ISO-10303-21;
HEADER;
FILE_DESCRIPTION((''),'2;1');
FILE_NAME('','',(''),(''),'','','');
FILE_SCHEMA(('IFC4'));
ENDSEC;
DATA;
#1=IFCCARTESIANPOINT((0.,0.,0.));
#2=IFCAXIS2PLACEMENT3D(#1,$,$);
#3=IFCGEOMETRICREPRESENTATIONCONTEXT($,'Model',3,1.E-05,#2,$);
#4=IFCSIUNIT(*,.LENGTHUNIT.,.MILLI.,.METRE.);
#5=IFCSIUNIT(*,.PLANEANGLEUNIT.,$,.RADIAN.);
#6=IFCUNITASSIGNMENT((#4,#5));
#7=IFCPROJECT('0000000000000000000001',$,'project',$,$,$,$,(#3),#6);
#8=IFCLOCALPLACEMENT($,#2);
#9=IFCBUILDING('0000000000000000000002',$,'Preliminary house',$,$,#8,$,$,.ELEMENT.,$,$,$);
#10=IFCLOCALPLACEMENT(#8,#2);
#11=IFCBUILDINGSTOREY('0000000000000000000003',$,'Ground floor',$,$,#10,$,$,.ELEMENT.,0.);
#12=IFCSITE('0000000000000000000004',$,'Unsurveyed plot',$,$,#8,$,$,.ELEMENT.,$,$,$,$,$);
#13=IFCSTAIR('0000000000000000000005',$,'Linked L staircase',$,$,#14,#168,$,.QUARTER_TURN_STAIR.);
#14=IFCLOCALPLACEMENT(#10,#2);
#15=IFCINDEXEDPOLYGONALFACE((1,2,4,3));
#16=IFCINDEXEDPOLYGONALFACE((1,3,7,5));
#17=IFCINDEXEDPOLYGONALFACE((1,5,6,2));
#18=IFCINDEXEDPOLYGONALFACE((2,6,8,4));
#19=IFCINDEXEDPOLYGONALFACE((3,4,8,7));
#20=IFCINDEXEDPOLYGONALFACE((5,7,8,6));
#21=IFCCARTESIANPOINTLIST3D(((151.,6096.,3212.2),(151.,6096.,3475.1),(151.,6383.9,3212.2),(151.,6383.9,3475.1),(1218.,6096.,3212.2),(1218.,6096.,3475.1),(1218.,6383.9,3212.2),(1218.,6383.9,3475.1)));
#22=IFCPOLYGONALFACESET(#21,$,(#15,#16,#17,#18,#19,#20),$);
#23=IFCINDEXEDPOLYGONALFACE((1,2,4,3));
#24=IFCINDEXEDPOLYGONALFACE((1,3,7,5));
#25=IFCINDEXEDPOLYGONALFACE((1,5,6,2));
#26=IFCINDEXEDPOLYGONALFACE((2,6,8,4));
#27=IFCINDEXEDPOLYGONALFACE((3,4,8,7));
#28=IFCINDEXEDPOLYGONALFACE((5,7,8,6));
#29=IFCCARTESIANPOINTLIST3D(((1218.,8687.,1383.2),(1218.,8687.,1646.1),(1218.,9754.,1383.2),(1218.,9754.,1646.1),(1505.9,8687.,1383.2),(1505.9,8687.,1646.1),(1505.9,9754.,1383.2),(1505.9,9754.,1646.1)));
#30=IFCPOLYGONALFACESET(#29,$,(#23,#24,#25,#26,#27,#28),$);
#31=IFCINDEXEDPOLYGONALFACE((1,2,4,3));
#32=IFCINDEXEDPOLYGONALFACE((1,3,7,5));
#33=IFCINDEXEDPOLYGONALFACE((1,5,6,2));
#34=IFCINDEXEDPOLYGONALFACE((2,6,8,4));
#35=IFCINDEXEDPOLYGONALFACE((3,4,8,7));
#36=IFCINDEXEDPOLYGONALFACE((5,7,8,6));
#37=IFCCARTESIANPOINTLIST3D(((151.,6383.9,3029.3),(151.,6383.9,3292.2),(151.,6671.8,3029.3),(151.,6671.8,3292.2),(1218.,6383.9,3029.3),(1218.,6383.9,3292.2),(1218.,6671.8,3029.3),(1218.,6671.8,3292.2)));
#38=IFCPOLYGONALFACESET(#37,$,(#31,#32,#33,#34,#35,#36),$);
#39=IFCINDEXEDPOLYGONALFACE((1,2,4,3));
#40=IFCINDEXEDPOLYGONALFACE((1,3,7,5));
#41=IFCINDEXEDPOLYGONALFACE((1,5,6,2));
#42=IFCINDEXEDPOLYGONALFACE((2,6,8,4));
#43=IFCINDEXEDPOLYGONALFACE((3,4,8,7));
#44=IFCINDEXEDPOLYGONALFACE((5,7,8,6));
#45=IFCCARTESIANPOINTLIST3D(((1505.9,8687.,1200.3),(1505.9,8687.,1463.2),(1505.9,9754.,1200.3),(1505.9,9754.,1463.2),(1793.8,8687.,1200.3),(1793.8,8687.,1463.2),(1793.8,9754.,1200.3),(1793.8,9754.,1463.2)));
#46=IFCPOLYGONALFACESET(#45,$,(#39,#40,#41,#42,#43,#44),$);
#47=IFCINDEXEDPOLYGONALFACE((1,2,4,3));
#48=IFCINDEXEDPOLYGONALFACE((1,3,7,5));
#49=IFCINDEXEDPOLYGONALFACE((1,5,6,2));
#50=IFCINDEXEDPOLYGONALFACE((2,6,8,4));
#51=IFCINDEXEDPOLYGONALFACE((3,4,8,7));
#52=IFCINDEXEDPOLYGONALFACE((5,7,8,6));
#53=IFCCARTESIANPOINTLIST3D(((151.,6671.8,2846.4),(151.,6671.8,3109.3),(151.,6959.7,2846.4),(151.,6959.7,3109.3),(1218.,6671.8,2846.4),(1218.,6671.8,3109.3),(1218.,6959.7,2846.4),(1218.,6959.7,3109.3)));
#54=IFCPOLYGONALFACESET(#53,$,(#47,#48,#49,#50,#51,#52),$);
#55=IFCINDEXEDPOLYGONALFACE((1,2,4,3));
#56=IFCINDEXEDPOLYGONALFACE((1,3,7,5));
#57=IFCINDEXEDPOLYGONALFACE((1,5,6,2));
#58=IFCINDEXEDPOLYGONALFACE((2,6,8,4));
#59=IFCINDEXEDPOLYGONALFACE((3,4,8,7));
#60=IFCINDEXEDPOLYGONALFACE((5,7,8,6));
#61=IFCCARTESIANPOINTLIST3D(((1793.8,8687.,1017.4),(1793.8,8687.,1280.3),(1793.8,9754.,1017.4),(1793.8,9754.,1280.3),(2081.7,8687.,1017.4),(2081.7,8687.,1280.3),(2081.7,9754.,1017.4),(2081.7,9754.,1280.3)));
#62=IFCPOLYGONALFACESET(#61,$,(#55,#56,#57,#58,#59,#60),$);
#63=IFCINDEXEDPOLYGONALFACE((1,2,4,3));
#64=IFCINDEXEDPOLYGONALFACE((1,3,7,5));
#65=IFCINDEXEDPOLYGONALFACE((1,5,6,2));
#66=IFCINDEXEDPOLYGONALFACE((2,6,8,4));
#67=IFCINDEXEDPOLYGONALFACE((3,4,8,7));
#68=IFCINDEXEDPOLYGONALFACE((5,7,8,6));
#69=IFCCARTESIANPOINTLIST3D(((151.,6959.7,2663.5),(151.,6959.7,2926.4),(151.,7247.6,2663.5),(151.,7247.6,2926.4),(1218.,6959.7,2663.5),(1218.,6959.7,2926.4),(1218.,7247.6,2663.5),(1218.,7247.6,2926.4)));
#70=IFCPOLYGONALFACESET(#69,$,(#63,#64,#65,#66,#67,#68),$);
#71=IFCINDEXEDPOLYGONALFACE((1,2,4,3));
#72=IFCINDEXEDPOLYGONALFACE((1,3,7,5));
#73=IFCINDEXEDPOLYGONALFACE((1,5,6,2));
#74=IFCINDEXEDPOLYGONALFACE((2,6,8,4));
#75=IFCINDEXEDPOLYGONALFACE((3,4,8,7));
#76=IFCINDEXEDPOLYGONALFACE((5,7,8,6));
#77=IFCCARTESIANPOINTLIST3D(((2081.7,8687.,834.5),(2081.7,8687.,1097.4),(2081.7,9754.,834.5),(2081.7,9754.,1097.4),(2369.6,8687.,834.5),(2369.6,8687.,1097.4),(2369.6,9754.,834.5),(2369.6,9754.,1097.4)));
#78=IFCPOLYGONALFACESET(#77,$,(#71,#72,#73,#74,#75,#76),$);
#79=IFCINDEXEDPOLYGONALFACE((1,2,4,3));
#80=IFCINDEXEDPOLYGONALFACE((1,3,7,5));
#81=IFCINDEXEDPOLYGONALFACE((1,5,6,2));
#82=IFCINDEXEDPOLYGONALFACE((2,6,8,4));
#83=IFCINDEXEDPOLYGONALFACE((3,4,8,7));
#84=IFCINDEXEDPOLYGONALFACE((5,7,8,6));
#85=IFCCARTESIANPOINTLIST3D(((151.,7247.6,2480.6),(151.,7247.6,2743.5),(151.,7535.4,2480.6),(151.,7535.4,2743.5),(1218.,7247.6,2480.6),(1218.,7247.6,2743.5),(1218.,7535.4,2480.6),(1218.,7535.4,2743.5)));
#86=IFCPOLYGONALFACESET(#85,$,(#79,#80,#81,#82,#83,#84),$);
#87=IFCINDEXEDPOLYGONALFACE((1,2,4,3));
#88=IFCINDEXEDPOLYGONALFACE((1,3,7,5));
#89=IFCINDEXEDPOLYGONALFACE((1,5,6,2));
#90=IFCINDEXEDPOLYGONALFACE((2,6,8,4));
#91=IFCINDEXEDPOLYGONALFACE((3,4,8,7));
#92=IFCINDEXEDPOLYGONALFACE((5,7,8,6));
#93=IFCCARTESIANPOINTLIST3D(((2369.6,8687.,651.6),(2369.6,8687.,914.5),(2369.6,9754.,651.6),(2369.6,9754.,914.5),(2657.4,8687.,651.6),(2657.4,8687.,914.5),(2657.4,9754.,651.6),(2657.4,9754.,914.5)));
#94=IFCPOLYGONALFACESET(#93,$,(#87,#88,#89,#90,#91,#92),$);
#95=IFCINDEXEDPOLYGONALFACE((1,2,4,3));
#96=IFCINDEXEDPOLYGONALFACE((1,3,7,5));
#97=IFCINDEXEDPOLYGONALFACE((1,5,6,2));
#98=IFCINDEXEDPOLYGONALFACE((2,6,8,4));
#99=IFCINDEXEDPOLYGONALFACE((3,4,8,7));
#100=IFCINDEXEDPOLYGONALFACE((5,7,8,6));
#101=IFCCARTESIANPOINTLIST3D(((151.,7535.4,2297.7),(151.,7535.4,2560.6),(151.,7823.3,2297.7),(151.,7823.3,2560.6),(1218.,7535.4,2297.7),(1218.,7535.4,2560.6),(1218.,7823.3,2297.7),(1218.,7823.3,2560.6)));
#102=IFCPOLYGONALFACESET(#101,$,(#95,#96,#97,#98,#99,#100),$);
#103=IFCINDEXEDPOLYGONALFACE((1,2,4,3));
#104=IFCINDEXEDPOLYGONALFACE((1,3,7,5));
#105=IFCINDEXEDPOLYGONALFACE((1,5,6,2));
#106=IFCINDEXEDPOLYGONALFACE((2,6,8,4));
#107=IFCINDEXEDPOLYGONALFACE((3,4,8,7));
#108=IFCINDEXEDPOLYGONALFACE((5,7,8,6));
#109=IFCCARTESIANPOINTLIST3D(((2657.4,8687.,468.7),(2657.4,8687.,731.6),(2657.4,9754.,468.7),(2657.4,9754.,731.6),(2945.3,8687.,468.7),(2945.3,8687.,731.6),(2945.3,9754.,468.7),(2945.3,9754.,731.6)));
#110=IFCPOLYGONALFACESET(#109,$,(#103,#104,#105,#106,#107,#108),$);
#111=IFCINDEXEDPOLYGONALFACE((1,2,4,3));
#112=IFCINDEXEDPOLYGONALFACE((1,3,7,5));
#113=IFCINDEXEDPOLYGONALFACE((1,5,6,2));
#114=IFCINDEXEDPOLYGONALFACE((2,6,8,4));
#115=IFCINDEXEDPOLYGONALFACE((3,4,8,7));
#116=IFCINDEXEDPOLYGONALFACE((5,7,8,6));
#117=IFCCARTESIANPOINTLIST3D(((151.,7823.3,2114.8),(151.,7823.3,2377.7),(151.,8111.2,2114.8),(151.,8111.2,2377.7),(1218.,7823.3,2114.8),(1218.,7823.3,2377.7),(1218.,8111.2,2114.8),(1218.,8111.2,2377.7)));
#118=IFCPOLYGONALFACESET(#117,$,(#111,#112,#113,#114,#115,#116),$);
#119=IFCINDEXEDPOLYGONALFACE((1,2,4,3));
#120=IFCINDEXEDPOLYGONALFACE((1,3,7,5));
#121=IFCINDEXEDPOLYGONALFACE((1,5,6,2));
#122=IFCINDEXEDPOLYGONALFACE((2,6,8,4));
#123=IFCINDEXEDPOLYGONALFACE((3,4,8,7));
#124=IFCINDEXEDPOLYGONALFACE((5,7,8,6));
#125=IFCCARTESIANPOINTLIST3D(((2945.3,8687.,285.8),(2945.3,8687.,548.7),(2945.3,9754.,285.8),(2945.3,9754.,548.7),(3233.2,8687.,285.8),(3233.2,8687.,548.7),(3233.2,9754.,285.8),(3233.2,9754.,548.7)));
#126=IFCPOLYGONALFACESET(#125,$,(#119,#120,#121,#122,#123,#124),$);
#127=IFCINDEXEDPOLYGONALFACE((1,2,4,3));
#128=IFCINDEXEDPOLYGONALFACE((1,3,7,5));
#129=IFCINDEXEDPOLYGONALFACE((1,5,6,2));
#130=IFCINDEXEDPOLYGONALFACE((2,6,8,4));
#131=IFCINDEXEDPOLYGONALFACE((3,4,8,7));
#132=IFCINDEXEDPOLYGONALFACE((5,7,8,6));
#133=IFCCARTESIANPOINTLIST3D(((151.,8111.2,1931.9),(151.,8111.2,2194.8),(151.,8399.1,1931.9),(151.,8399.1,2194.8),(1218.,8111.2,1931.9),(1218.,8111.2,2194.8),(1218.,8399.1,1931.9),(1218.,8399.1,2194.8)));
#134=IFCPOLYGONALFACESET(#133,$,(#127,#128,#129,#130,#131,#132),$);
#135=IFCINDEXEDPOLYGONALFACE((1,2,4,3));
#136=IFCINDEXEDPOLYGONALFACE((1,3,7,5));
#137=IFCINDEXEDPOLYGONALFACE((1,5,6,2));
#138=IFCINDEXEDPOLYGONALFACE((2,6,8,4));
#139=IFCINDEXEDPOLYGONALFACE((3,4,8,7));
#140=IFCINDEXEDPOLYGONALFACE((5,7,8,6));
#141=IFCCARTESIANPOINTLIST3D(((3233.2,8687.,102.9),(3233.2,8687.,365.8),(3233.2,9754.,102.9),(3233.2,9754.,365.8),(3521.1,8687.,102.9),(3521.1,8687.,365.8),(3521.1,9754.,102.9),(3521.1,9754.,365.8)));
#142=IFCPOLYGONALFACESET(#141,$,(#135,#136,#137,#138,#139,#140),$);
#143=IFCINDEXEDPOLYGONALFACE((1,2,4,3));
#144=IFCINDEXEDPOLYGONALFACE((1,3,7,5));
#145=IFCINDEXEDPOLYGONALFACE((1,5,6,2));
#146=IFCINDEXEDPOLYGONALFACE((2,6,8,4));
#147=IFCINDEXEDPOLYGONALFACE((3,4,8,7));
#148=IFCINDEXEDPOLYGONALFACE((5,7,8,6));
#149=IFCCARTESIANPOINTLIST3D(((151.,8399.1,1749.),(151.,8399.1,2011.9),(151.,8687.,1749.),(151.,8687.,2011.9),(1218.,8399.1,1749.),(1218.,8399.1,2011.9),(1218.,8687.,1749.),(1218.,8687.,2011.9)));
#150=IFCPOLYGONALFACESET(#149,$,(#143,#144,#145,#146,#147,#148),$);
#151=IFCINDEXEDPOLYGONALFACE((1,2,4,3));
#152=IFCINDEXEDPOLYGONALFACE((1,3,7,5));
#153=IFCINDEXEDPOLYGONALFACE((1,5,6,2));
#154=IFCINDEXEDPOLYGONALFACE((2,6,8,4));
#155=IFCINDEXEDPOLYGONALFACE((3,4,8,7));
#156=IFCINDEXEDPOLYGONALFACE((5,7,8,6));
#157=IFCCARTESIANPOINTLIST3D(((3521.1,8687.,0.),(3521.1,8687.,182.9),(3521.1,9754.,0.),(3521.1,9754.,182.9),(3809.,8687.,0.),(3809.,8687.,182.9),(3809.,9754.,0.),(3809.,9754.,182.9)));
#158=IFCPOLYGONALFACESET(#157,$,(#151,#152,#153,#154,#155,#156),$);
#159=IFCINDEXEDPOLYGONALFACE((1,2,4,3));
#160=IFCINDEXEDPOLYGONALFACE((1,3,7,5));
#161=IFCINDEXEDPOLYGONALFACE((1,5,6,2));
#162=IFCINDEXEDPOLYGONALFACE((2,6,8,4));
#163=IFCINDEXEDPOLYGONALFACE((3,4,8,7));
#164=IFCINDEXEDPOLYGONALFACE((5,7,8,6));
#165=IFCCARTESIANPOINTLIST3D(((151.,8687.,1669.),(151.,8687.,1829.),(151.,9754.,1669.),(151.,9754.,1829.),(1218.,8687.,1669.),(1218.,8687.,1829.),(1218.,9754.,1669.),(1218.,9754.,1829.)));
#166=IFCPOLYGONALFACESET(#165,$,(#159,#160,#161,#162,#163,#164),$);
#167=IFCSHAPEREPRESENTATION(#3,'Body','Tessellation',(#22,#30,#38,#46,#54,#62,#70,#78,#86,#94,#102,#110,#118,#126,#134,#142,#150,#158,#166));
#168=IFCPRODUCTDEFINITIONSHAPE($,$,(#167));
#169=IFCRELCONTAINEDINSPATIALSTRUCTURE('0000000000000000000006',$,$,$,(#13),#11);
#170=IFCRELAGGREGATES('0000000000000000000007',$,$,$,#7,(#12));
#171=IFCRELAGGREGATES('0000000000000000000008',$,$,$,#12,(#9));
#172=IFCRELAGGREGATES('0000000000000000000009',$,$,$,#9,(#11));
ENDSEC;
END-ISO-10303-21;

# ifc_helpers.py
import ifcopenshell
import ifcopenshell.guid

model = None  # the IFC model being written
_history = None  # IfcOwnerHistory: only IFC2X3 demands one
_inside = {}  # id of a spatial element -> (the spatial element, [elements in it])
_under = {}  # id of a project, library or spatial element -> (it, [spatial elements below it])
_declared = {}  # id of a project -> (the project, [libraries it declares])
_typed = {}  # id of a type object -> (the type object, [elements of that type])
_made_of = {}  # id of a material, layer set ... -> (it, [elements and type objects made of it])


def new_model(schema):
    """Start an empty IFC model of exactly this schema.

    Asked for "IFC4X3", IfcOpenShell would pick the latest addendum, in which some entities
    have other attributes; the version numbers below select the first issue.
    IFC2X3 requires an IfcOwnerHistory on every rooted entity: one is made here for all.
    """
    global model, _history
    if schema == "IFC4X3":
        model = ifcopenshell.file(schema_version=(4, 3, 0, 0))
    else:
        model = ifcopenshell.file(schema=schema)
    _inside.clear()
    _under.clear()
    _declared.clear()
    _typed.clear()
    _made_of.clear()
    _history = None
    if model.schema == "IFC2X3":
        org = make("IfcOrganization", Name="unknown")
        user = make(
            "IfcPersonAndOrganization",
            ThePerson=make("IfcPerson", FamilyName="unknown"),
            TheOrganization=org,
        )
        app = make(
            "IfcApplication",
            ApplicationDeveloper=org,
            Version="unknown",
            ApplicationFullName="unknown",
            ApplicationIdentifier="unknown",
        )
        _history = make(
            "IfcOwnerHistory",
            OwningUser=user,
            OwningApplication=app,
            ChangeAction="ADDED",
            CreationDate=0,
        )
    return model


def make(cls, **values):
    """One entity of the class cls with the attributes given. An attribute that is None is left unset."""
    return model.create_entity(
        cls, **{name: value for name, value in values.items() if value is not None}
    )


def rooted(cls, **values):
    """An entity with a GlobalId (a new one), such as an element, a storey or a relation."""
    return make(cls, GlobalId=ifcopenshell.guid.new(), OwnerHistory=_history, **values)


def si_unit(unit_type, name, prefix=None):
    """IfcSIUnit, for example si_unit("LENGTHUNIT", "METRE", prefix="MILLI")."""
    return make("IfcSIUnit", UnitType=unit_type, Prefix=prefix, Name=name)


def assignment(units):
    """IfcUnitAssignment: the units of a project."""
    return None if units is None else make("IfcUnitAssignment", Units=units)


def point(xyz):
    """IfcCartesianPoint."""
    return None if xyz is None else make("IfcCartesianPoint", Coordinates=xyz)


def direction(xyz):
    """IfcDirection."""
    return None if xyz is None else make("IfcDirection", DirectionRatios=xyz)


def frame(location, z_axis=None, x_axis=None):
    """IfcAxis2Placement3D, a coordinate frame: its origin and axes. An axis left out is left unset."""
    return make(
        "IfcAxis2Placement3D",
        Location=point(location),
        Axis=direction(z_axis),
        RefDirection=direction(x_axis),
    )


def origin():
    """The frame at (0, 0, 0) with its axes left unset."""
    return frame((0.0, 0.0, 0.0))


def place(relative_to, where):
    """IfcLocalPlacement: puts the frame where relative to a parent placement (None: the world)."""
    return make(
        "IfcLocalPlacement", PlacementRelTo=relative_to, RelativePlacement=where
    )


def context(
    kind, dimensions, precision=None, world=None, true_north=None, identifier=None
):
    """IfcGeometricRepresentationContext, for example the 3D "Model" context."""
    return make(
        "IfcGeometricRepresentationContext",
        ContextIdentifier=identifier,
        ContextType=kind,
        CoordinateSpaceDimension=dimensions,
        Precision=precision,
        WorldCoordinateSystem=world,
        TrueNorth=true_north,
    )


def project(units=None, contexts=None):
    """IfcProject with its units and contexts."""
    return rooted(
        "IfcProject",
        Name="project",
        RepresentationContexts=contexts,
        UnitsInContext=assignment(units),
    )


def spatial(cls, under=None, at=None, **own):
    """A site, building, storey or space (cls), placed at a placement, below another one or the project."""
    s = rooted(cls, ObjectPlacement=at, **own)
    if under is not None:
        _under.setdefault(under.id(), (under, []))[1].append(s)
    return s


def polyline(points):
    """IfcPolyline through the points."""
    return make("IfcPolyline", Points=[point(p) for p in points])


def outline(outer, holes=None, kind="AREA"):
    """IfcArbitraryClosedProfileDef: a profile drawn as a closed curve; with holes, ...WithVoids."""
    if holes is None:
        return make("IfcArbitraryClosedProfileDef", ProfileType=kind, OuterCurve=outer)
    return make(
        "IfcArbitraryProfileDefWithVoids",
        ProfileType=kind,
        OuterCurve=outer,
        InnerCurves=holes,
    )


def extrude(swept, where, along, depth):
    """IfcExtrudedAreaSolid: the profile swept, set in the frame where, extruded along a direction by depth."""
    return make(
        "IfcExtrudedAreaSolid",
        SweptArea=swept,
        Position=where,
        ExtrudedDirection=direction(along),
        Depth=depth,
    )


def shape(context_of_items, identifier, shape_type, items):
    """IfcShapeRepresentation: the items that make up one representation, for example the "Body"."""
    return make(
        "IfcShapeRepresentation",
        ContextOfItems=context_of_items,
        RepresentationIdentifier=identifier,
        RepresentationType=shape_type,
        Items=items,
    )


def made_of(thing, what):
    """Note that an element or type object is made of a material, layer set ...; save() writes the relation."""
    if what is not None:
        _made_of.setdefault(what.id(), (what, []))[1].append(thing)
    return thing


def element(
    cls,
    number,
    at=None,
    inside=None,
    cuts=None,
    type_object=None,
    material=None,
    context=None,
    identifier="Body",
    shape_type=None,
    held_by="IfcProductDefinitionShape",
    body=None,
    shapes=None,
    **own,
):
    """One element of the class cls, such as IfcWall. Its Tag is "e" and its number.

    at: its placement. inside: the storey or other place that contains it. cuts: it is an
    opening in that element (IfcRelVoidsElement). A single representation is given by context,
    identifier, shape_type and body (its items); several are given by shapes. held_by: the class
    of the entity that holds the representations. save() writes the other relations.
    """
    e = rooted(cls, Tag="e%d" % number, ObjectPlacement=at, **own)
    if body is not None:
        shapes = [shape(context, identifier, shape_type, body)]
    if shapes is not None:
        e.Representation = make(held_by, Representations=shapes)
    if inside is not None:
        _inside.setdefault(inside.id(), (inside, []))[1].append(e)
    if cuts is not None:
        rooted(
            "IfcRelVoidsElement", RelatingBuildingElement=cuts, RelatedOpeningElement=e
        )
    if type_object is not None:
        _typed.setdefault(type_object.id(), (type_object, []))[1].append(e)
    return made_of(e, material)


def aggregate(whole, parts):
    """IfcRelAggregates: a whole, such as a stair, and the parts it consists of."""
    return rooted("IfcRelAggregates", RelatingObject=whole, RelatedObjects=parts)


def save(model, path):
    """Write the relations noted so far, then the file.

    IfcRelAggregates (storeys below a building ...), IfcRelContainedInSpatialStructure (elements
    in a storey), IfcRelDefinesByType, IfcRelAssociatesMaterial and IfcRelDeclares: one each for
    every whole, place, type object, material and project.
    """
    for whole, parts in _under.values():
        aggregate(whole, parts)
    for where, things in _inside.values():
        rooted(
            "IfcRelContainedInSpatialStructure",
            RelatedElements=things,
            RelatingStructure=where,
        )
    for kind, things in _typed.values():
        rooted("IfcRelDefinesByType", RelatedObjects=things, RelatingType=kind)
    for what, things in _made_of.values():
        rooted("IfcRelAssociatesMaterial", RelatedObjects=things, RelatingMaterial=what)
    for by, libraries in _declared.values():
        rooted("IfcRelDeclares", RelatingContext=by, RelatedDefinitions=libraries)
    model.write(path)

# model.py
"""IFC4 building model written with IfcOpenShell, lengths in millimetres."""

from ifc_helpers import new_model, si_unit, frame, origin, place, context, project, spatial, polyline, outline, extrude, element, save


model = new_model("IFC4")

# Units and contexts
model_context = context("Model", 3, precision=1e-05, world=origin())
ifc_project = project(units=[si_unit("LENGTHUNIT", "METRE", prefix="MILLI"), si_unit("PLANEANGLEUNIT", "RADIAN")], contexts=[model_context])

# Site, building, storey
placement_1 = place(None, origin())
site = spatial("IfcSite", under=ifc_project, at=placement_1, Name="Unsurveyed plot", CompositionType="ELEMENT")
building = spatial("IfcBuilding", under=site, at=placement_1, Name="Preliminary house", CompositionType="ELEMENT")
placement_2 = place(placement_1, origin())
storey = spatial("IfcBuildingStorey", under=building, at=placement_2, Name="Ground floor", CompositionType="ELEMENT", Elevation=0.0)

# Stair
element("IfcStair", 1, at=placement_2, inside=storey, Name="Linked L staircase", PredefinedType="QUARTER_TURN_STAIR", context=model_context, shape_type="SweptSolid", body=[
    extrude(outline(polyline([(1218.0, 6096.0), (1218.0, 6383.9), (151.0, 6383.9), (151.0, 6096.0), (1218.0, 6096.0)])), frame((0.0, 0.0, 3212.2)), (0.0, 0.0, 1.0), 262.9),
    extrude(outline(polyline([(1505.9, 8687.0), (1505.9, 9754.0), (1218.0, 9754.0), (1218.0, 8687.0), (1505.9, 8687.0)])), frame((0.0, 0.0, 1383.2)), (0.0, 0.0, 1.0), 262.9),
    extrude(outline(polyline([(1218.0, 6383.9), (1218.0, 6671.8), (151.0, 6671.8), (151.0, 6383.9), (1218.0, 6383.9)])), frame((0.0, 0.0, 3029.3)), (0.0, 0.0, 1.0), 262.9),
    extrude(outline(polyline([(1793.8, 8687.0), (1793.8, 9754.0), (1505.9, 9754.0), (1505.9, 8687.0), (1793.8, 8687.0)])), frame((0.0, 0.0, 1200.3)), (0.0, 0.0, 1.0), 262.9),
    extrude(outline(polyline([(1218.0, 6671.8), (1218.0, 6959.7), (151.0, 6959.7), (151.0, 6671.8), (1218.0, 6671.8)])), frame((0.0, 0.0, 2846.4)), (0.0, 0.0, 1.0), 262.9),
    extrude(outline(polyline([(2081.7, 8687.0), (2081.7, 9754.0), (1793.8, 9754.0), (1793.8, 8687.0), (2081.7, 8687.0)])), frame((0.0, 0.0, 1017.4)), (0.0, 0.0, 1.0), 262.9),
    extrude(outline(polyline([(1218.0, 6959.7), (1218.0, 7247.6), (151.0, 7247.6), (151.0, 6959.7), (1218.0, 6959.7)])), frame((0.0, 0.0, 2663.5)), (0.0, 0.0, 1.0), 262.9),
    extrude(outline(polyline([(2369.6, 8687.0), (2369.6, 9754.0), (2081.7, 9754.0), (2081.7, 8687.0), (2369.6, 8687.0)])), frame((0.0, 0.0, 834.5)), (0.0, 0.0, 1.0), 262.9),
    extrude(outline(polyline([(1218.0, 7247.6), (1218.0, 7535.4), (151.0, 7535.4), (151.0, 7247.6), (1218.0, 7247.6)])), frame((0.0, 0.0, 2480.6)), (0.0, 0.0, 1.0), 262.9),
    extrude(outline(polyline([(2657.4, 8687.0), (2657.4, 9754.0), (2369.6, 9754.0), (2369.6, 8687.0), (2657.4, 8687.0)])), frame((0.0, 0.0, 651.6)), (0.0, 0.0, 1.0), 262.9),
    extrude(outline(polyline([(1218.0, 7535.4), (1218.0, 7823.3), (151.0, 7823.3), (151.0, 7535.4), (1218.0, 7535.4)])), frame((0.0, 0.0, 2297.7)), (0.0, 0.0, 1.0), 262.9),
    extrude(outline(polyline([(2945.3, 8687.0), (2945.3, 9754.0), (2657.4, 9754.0), (2657.4, 8687.0), (2945.3, 8687.0)])), frame((0.0, 0.0, 468.7)), (0.0, 0.0, 1.0), 262.9),
    extrude(outline(polyline([(1218.0, 7823.3), (1218.0, 8111.2), (151.0, 8111.2), (151.0, 7823.3), (1218.0, 7823.3)])), frame((0.0, 0.0, 2114.8)), (0.0, 0.0, 1.0), 262.9),
    extrude(outline(polyline([(3233.2, 8687.0), (3233.2, 9754.0), (2945.3, 9754.0), (2945.3, 8687.0), (3233.2, 8687.0)])), frame((0.0, 0.0, 285.8)), (0.0, 0.0, 1.0), 262.9),
    extrude(outline(polyline([(1218.0, 8111.2), (1218.0, 8399.1), (151.0, 8399.1), (151.0, 8111.2), (1218.0, 8111.2)])), frame((0.0, 0.0, 1931.9)), (0.0, 0.0, 1.0), 262.9),
    extrude(outline(polyline([(3521.1, 8687.0), (3521.1, 9754.0), (3233.2, 9754.0), (3233.2, 8687.0), (3521.1, 8687.0)])), frame((0.0, 0.0, 102.9)), (0.0, 0.0, 1.0), 262.9),
    extrude(outline(polyline([(1218.0, 8399.1), (1218.0, 8687.0), (151.0, 8687.0), (151.0, 8399.1), (1218.0, 8399.1)])), frame((0.0, 0.0, 1749.0)), (0.0, 0.0, 1.0), 262.9),
    extrude(outline(polyline([(3809.0, 8687.0), (3809.0, 9754.0), (3521.1, 9754.0), (3521.1, 8687.0), (3809.0, 8687.0)])), origin(), (0.0, 0.0, 1.0), 182.9),
    extrude(outline(polyline([(1218.0, 8687.0), (1218.0, 9754.0), (151.0, 9754.0), (151.0, 8687.0), (1218.0, 8687.0)])), frame((0.0, 0.0, 1669.0)), (0.0, 0.0, 1.0), 160.0),
])

save(model, "model.ifc")
